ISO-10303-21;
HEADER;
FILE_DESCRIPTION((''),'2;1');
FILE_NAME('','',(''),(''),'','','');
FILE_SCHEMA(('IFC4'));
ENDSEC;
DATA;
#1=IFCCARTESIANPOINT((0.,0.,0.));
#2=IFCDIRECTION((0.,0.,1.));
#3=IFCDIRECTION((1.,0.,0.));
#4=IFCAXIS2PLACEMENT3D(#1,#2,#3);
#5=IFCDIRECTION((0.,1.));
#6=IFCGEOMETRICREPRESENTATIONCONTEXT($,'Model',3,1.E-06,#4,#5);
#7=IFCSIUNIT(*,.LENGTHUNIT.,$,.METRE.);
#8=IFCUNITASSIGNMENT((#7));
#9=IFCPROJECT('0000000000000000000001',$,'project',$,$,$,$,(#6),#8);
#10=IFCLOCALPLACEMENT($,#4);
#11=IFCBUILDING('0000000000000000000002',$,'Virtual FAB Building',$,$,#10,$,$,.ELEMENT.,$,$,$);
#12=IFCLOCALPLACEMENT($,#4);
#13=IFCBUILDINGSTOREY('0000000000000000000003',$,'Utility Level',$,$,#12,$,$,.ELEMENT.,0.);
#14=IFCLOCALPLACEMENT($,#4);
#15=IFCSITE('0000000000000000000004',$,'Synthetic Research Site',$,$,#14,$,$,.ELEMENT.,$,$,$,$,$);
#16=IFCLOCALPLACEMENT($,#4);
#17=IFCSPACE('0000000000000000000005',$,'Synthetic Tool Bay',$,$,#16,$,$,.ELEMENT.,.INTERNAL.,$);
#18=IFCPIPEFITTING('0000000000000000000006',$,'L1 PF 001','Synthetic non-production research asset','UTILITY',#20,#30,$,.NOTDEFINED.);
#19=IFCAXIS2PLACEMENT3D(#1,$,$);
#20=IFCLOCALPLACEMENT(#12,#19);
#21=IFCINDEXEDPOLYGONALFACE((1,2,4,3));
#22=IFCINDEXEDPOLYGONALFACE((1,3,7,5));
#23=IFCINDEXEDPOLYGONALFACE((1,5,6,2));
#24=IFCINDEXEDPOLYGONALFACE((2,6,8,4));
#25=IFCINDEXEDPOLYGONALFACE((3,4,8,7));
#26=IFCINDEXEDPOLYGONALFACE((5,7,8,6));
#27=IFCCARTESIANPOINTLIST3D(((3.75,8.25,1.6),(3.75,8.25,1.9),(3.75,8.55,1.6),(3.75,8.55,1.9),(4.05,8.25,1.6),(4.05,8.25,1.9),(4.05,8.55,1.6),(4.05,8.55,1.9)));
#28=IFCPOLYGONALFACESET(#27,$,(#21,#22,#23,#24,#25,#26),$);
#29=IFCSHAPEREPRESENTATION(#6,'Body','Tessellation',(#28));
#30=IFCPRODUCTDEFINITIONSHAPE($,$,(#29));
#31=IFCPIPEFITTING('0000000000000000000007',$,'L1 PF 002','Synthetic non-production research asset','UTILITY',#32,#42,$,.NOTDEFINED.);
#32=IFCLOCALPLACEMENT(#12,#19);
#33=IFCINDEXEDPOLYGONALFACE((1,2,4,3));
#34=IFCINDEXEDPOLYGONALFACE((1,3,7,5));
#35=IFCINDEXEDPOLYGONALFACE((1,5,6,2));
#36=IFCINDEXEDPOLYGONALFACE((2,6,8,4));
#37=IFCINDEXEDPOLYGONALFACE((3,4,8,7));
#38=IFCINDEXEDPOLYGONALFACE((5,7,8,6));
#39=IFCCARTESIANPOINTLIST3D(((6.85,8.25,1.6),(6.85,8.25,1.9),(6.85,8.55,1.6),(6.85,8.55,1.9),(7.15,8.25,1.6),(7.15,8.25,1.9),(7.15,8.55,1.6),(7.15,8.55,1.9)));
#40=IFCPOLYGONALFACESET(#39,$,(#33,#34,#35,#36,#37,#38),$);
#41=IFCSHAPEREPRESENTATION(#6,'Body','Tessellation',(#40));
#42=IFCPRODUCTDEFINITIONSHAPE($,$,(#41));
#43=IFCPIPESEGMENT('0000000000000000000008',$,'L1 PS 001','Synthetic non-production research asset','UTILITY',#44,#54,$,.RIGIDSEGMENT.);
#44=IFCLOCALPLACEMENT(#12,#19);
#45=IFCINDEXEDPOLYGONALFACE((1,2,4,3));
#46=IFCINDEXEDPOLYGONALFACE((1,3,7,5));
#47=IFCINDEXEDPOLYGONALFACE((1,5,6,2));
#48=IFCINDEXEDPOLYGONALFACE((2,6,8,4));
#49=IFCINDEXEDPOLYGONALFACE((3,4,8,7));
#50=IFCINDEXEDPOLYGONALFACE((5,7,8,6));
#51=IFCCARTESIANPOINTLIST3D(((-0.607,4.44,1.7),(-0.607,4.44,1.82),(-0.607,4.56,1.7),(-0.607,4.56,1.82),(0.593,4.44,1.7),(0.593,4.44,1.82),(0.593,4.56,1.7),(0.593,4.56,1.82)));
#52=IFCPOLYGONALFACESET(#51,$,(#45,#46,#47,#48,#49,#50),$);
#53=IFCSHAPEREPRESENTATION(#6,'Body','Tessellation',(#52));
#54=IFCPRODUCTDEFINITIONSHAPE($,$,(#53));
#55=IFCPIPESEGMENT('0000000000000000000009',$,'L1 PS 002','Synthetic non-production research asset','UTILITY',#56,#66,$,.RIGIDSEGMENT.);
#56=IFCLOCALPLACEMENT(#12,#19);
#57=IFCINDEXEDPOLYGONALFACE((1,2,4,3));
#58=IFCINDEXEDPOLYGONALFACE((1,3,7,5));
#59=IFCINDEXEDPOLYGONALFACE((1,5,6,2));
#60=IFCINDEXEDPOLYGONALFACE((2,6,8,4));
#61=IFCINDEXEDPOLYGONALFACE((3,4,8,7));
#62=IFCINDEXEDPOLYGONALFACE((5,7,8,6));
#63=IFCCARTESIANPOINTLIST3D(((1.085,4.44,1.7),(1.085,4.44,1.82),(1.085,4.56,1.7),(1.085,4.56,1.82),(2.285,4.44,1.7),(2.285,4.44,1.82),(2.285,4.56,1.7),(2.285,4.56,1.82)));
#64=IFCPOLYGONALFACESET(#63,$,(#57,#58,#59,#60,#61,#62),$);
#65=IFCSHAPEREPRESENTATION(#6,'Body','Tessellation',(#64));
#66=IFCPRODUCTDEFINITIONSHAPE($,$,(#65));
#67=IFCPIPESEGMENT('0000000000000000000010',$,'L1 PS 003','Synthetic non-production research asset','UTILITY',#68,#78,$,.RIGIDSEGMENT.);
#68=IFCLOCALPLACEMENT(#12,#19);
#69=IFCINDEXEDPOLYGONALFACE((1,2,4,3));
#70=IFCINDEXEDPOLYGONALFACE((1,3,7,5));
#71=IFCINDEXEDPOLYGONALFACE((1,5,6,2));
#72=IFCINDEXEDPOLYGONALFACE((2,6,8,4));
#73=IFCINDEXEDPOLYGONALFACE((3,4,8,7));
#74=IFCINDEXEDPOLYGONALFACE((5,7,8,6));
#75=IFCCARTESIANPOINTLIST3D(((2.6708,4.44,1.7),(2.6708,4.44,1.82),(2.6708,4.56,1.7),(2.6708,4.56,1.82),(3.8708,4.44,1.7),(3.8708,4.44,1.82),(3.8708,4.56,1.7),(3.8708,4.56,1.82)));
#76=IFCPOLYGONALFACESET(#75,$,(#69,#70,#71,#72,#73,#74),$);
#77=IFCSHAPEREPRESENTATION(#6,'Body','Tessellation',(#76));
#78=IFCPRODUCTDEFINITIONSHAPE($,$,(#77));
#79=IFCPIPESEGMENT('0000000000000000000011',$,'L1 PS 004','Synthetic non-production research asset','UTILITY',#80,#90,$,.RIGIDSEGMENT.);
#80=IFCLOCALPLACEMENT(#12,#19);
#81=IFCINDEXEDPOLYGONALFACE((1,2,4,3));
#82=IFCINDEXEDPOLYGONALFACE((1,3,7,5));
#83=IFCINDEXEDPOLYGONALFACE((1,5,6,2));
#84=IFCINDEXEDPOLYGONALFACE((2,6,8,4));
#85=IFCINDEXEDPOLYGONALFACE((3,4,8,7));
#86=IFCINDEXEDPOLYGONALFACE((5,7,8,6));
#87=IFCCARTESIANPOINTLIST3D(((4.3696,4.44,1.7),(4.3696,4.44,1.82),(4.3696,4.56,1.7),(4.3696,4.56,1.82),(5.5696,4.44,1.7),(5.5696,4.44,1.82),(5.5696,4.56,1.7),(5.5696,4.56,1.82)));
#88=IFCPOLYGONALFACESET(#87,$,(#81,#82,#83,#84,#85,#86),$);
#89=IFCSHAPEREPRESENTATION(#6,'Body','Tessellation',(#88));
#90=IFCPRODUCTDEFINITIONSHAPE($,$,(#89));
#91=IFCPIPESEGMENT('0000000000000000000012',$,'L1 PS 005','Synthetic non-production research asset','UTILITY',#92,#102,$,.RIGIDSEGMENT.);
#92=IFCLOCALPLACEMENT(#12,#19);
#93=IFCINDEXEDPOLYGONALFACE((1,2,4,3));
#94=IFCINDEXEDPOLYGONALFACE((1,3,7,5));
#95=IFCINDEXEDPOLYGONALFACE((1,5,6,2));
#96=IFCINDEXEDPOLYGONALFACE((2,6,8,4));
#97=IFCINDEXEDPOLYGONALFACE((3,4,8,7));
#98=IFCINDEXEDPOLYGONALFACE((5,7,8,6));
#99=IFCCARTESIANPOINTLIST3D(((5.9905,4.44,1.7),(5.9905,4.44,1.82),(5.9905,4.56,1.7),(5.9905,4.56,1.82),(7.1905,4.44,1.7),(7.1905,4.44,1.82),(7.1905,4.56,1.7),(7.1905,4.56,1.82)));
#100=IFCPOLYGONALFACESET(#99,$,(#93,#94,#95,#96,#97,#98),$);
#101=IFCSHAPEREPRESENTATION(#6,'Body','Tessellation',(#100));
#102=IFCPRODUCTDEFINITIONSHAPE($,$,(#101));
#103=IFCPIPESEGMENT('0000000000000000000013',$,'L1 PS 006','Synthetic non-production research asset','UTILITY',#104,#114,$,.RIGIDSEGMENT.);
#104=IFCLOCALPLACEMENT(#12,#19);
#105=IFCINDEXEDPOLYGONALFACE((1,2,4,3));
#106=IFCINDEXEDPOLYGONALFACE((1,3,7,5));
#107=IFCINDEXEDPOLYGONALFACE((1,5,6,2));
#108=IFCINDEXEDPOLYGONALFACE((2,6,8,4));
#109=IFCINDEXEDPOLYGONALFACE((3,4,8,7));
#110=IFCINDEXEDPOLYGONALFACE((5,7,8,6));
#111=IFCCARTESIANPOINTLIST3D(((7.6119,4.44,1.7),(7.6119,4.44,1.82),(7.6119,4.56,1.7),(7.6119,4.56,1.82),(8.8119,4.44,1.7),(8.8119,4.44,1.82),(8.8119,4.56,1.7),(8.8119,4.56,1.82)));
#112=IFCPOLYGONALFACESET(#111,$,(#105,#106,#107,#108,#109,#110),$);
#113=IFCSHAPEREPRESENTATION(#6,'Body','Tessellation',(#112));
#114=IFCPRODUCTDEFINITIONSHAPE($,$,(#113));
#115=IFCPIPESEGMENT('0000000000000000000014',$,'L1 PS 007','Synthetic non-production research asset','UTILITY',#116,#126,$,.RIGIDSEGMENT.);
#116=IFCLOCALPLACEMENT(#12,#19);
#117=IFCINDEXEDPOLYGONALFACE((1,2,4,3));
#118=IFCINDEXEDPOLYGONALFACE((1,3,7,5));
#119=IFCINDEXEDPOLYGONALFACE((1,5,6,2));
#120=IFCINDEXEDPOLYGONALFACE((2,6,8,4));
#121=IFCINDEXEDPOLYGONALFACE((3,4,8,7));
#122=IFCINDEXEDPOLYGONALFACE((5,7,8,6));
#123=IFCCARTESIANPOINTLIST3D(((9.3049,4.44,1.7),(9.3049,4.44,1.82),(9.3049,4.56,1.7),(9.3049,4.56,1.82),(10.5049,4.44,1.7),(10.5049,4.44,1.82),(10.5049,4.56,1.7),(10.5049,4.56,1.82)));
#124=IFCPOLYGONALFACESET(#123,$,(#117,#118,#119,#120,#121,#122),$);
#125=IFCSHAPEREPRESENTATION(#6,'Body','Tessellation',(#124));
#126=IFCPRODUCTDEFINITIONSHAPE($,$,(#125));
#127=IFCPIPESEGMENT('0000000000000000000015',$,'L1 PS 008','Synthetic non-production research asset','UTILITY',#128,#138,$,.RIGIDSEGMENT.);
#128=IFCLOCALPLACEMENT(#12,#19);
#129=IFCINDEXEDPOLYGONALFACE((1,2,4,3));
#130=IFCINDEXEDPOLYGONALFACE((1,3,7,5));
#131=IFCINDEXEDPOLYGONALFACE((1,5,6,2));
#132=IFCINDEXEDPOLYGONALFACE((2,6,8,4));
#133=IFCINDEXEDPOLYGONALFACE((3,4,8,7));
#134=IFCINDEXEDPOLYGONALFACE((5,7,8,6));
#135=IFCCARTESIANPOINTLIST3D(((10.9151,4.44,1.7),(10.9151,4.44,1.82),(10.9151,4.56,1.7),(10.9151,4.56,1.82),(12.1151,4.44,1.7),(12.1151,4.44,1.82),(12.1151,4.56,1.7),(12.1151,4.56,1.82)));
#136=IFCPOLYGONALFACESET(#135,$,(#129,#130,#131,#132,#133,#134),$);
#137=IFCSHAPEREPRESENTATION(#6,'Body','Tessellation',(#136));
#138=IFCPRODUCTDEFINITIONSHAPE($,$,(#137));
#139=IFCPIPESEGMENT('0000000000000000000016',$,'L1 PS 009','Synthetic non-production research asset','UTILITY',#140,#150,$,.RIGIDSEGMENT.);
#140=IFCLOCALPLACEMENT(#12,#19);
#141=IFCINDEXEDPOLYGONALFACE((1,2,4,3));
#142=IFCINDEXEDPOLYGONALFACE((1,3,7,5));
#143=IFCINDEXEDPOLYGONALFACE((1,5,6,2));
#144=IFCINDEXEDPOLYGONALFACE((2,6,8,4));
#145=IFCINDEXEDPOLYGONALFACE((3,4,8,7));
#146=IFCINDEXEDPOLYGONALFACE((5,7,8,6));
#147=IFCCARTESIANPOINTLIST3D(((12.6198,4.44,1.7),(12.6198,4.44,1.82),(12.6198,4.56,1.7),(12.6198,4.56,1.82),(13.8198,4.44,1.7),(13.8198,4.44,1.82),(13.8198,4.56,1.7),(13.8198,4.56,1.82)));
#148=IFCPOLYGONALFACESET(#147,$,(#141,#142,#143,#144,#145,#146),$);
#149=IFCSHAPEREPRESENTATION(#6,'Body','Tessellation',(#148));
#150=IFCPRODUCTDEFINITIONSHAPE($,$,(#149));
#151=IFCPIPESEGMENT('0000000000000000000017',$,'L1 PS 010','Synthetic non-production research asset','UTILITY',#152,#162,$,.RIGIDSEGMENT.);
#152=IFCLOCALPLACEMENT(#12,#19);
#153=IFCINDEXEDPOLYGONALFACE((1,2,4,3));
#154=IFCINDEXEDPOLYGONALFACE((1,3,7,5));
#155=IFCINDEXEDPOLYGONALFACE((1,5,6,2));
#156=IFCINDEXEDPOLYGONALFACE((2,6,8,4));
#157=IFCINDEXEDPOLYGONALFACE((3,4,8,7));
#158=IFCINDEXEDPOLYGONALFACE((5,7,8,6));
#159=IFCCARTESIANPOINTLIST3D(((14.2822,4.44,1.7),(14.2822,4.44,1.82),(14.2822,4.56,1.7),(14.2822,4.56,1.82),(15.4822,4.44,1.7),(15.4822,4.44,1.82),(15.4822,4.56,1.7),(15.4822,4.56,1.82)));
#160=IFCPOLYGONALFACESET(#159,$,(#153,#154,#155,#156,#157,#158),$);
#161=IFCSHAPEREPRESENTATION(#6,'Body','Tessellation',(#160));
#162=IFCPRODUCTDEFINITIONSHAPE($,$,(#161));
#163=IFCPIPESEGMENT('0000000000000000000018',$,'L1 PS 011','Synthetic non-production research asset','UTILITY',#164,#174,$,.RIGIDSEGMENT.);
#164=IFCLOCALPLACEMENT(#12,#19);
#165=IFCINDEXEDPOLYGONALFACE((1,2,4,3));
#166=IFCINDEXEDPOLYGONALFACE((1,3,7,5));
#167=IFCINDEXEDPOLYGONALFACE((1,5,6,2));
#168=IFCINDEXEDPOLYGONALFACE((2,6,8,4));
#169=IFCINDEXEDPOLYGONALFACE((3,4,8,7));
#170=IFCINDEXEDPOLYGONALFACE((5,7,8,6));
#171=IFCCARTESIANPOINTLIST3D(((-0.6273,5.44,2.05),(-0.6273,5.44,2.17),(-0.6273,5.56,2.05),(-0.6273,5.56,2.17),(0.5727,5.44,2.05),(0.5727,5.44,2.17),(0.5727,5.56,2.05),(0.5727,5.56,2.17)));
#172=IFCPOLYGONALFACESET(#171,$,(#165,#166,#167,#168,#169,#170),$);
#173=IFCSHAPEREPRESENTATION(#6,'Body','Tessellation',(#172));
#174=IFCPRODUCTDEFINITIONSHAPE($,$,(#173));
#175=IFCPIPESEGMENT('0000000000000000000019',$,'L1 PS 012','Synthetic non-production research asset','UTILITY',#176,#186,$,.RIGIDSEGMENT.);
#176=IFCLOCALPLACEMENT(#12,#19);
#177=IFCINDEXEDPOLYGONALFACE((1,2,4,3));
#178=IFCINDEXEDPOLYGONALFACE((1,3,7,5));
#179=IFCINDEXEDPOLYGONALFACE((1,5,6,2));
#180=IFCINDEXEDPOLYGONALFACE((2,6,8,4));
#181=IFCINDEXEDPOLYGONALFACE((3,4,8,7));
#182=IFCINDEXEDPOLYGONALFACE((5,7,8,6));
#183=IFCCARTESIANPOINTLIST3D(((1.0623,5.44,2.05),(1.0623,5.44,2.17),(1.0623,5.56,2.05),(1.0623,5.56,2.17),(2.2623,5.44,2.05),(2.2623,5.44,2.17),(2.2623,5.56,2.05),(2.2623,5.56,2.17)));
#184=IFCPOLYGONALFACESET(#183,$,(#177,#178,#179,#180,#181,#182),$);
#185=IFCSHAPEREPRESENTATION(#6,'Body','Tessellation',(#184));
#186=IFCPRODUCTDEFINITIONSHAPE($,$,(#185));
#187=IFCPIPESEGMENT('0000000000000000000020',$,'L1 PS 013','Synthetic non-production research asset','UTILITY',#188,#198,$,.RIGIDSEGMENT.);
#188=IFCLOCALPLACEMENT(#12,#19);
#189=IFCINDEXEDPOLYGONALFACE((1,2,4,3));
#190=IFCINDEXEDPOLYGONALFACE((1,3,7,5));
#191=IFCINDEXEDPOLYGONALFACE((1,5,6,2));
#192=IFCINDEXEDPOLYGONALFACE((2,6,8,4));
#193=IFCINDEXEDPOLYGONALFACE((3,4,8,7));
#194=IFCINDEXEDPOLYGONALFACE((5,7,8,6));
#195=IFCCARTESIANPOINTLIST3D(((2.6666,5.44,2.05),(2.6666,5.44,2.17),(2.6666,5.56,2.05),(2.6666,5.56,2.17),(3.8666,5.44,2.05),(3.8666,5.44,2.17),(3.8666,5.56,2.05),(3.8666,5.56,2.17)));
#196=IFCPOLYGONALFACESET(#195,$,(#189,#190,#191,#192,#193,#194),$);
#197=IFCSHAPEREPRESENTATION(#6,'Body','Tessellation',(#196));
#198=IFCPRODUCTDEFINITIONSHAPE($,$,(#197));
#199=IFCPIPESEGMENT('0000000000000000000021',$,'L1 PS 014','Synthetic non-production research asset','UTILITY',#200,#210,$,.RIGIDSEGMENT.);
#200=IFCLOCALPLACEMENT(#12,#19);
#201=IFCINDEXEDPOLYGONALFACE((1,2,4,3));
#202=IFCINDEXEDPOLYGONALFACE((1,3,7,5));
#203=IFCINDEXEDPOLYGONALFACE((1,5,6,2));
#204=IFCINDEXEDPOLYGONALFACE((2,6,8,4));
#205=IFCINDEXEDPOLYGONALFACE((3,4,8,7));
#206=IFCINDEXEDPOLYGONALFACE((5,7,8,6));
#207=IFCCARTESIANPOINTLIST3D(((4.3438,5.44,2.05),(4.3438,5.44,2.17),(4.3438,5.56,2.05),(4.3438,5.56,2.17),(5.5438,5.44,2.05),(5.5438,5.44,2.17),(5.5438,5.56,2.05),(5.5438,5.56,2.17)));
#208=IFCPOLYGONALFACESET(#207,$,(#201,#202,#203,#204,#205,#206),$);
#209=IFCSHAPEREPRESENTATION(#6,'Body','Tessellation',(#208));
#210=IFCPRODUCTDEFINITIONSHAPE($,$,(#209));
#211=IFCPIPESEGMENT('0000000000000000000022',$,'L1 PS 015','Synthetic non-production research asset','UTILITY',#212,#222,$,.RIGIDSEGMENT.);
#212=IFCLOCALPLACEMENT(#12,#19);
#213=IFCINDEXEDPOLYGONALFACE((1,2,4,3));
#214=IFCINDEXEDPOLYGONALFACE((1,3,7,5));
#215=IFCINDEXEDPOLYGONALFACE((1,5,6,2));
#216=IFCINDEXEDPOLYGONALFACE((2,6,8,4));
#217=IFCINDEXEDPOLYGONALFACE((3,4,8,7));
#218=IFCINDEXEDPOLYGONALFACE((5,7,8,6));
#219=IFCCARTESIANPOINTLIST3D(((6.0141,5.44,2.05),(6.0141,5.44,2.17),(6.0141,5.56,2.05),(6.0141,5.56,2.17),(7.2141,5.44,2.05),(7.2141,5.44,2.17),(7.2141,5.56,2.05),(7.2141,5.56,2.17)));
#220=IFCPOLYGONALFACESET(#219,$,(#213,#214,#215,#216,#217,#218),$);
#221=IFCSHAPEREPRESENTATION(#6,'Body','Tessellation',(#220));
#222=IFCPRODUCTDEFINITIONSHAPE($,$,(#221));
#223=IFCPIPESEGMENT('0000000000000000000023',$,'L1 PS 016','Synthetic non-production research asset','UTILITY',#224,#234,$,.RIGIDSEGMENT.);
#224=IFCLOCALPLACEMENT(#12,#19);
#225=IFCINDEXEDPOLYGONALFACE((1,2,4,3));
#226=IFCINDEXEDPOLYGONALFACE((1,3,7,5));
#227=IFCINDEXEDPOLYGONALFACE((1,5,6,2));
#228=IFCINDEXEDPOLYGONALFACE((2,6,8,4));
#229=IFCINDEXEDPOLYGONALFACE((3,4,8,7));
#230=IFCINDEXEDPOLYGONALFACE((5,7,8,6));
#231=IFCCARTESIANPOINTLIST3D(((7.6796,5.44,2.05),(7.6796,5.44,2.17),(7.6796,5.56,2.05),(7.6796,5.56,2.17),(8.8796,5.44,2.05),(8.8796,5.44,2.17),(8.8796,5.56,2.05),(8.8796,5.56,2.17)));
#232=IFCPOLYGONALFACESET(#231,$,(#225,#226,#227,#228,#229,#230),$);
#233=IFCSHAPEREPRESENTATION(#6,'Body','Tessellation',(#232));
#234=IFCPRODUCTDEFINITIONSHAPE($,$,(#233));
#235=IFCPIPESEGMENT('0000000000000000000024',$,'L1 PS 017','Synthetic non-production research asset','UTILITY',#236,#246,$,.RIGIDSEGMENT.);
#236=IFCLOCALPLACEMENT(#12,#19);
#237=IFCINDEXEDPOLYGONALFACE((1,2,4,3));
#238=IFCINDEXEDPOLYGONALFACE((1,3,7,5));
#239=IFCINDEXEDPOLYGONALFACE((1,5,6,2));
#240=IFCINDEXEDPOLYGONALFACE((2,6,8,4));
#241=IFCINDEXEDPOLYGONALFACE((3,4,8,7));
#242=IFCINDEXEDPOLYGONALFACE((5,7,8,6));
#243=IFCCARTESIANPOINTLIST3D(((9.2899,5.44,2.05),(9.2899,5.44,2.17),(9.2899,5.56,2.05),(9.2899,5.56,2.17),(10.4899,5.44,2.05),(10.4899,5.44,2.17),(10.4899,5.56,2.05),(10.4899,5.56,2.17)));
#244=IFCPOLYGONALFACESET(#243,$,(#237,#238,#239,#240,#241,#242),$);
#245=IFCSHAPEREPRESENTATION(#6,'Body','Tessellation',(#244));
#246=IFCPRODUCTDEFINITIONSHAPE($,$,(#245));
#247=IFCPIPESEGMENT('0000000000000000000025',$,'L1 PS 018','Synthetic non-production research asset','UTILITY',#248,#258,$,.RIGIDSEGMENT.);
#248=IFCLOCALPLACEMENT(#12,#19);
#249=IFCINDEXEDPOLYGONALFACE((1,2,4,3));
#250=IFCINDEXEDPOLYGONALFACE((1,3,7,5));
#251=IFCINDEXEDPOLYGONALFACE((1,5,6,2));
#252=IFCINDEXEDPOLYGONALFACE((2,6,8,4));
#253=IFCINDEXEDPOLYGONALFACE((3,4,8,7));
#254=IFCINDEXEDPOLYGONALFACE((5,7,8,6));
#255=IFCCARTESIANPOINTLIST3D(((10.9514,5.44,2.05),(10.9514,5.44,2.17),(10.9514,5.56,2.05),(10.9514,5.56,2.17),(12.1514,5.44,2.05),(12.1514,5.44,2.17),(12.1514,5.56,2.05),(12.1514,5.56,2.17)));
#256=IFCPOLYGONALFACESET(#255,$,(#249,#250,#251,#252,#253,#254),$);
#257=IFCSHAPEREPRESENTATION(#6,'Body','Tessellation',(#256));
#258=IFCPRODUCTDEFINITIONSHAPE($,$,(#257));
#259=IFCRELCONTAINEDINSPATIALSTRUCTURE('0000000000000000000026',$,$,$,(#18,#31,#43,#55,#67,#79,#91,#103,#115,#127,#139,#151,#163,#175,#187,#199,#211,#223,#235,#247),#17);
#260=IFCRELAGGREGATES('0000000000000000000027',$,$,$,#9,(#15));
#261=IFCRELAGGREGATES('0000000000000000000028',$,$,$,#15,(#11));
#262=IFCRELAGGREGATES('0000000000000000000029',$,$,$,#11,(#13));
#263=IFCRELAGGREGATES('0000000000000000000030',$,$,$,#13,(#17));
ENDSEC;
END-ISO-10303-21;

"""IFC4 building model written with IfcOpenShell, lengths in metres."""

from ifc_helpers import new_model, si_unit, direction, frame, origin_with_axes, origin_2d_with_axis, place, context, project, spatial, rectangle, extrude, element, save


model = new_model("IFC4")

# Units and contexts
model_context = context("Model", 3, precision=1e-06, world=origin_with_axes(), true_north=direction((0.0, 1.0)))
ifc_project = project(units=[si_unit("LENGTHUNIT", "METRE")], contexts=[model_context])

# Site, building, storey, space
site_placement = place(None, origin_with_axes())
site = spatial("IfcSite", under=ifc_project, at=site_placement, Name="Synthetic Research Site", CompositionType="ELEMENT")
building_placement = place(None, origin_with_axes())
building = spatial("IfcBuilding", under=site, at=building_placement, Name="Virtual FAB Building", CompositionType="ELEMENT")
storey_placement = place(None, origin_with_axes())
storey = spatial("IfcBuildingStorey", under=building, at=storey_placement, Name="Utility Level", CompositionType="ELEMENT", Elevation=0.0)
space_placement = place(None, origin_with_axes())
space = spatial("IfcSpace", under=storey, at=space_placement, Name="Synthetic Tool Bay", CompositionType="ELEMENT", PredefinedType="INTERNAL")

# Pipe fittings
for number, where, z_axis, x_axis, name in (
    (1, (3.9, 8.4, 1.6), (0.0, 0.0, 1.0), (1.0, 0.0, 0.0), "L1 PF 001"),
    (2, (7.0, 8.4, 1.6), (0.0, 0.0, 1.0), (1.0, 0.0, 0.0), "L1 PF 002"),
):
    element("IfcPipeFitting", number, at=place(None, frame(where, z_axis=z_axis, x_axis=x_axis)), inside=space, Name=name, Description="Synthetic non-production research asset", ObjectType="UTILITY", PredefinedType="NOTDEFINED", context=model_context, shape_type="SweptSolid", body=[
        extrude(rectangle(XDim=0.3, YDim=0.3, at=origin_2d_with_axis()), origin_with_axes(), (0.0, 0.0, 1.0), 0.3),
    ])

# Pipe segments
for number, where, z_axis, x_axis, name in (
    (3, (-0.007, 4.5, 1.7), (0.0, 0.0, 1.0), (1.0, 0.0, 0.0), "L1 PS 001"),
    (4, (1.685, 4.5, 1.7), (0.0, 0.0, 1.0), (1.0, 0.0, 0.0), "L1 PS 002"),
    (5, (3.2708, 4.5, 1.7), (0.0, 0.0, 1.0), (1.0, 0.0, 0.0), "L1 PS 003"),
    (6, (4.9696, 4.5, 1.7), (0.0, 0.0, 1.0), (1.0, 0.0, 0.0), "L1 PS 004"),
    (7, (6.5905, 4.5, 1.7), (0.0, 0.0, 1.0), (1.0, 0.0, 0.0), "L1 PS 005"),
    (8, (8.2119, 4.5, 1.7), (0.0, 0.0, 1.0), (1.0, 0.0, 0.0), "L1 PS 006"),
    (9, (9.9049, 4.5, 1.7), (0.0, 0.0, 1.0), (1.0, 0.0, 0.0), "L1 PS 007"),
    (10, (11.5151, 4.5, 1.7), (0.0, 0.0, 1.0), (1.0, 0.0, 0.0), "L1 PS 008"),
    (11, (13.2198, 4.5, 1.7), (0.0, 0.0, 1.0), (1.0, 0.0, 0.0), "L1 PS 009"),
    (12, (14.8822, 4.5, 1.7), (0.0, 0.0, 1.0), (1.0, 0.0, 0.0), "L1 PS 010"),
    (13, (-0.0273, 5.5, 2.05), (0.0, 0.0, 1.0), (1.0, 0.0, 0.0), "L1 PS 011"),
    (14, (1.6623, 5.5, 2.05), (0.0, 0.0, 1.0), (1.0, 0.0, 0.0), "L1 PS 012"),
    (15, (3.2666, 5.5, 2.05), (0.0, 0.0, 1.0), (1.0, 0.0, 0.0), "L1 PS 013"),
    (16, (4.9438, 5.5, 2.05), (0.0, 0.0, 1.0), (1.0, 0.0, 0.0), "L1 PS 014"),
    (17, (6.6141, 5.5, 2.05), (0.0, 0.0, 1.0), (1.0, 0.0, 0.0), "L1 PS 015"),
    (18, (8.2796, 5.5, 2.05), (0.0, 0.0, 1.0), (1.0, 0.0, 0.0), "L1 PS 016"),
    (19, (9.8899, 5.5, 2.05), (0.0, 0.0, 1.0), (1.0, 0.0, 0.0), "L1 PS 017"),
    (20, (11.5514, 5.5, 2.05), (0.0, 0.0, 1.0), (1.0, 0.0, 0.0), "L1 PS 018"),
):
    element("IfcPipeSegment", number, at=place(None, frame(where, z_axis=z_axis, x_axis=x_axis)), inside=space, Name=name, Description="Synthetic non-production research asset", ObjectType="UTILITY", PredefinedType="RIGIDSEGMENT", context=model_context, shape_type="SweptSolid", body=[
        extrude(rectangle(XDim=1.2, YDim=0.12, at=origin_2d_with_axis()), origin_with_axes(), (0.0, 0.0, 1.0), 0.12),
    ])

save(model, "model.ifc")
